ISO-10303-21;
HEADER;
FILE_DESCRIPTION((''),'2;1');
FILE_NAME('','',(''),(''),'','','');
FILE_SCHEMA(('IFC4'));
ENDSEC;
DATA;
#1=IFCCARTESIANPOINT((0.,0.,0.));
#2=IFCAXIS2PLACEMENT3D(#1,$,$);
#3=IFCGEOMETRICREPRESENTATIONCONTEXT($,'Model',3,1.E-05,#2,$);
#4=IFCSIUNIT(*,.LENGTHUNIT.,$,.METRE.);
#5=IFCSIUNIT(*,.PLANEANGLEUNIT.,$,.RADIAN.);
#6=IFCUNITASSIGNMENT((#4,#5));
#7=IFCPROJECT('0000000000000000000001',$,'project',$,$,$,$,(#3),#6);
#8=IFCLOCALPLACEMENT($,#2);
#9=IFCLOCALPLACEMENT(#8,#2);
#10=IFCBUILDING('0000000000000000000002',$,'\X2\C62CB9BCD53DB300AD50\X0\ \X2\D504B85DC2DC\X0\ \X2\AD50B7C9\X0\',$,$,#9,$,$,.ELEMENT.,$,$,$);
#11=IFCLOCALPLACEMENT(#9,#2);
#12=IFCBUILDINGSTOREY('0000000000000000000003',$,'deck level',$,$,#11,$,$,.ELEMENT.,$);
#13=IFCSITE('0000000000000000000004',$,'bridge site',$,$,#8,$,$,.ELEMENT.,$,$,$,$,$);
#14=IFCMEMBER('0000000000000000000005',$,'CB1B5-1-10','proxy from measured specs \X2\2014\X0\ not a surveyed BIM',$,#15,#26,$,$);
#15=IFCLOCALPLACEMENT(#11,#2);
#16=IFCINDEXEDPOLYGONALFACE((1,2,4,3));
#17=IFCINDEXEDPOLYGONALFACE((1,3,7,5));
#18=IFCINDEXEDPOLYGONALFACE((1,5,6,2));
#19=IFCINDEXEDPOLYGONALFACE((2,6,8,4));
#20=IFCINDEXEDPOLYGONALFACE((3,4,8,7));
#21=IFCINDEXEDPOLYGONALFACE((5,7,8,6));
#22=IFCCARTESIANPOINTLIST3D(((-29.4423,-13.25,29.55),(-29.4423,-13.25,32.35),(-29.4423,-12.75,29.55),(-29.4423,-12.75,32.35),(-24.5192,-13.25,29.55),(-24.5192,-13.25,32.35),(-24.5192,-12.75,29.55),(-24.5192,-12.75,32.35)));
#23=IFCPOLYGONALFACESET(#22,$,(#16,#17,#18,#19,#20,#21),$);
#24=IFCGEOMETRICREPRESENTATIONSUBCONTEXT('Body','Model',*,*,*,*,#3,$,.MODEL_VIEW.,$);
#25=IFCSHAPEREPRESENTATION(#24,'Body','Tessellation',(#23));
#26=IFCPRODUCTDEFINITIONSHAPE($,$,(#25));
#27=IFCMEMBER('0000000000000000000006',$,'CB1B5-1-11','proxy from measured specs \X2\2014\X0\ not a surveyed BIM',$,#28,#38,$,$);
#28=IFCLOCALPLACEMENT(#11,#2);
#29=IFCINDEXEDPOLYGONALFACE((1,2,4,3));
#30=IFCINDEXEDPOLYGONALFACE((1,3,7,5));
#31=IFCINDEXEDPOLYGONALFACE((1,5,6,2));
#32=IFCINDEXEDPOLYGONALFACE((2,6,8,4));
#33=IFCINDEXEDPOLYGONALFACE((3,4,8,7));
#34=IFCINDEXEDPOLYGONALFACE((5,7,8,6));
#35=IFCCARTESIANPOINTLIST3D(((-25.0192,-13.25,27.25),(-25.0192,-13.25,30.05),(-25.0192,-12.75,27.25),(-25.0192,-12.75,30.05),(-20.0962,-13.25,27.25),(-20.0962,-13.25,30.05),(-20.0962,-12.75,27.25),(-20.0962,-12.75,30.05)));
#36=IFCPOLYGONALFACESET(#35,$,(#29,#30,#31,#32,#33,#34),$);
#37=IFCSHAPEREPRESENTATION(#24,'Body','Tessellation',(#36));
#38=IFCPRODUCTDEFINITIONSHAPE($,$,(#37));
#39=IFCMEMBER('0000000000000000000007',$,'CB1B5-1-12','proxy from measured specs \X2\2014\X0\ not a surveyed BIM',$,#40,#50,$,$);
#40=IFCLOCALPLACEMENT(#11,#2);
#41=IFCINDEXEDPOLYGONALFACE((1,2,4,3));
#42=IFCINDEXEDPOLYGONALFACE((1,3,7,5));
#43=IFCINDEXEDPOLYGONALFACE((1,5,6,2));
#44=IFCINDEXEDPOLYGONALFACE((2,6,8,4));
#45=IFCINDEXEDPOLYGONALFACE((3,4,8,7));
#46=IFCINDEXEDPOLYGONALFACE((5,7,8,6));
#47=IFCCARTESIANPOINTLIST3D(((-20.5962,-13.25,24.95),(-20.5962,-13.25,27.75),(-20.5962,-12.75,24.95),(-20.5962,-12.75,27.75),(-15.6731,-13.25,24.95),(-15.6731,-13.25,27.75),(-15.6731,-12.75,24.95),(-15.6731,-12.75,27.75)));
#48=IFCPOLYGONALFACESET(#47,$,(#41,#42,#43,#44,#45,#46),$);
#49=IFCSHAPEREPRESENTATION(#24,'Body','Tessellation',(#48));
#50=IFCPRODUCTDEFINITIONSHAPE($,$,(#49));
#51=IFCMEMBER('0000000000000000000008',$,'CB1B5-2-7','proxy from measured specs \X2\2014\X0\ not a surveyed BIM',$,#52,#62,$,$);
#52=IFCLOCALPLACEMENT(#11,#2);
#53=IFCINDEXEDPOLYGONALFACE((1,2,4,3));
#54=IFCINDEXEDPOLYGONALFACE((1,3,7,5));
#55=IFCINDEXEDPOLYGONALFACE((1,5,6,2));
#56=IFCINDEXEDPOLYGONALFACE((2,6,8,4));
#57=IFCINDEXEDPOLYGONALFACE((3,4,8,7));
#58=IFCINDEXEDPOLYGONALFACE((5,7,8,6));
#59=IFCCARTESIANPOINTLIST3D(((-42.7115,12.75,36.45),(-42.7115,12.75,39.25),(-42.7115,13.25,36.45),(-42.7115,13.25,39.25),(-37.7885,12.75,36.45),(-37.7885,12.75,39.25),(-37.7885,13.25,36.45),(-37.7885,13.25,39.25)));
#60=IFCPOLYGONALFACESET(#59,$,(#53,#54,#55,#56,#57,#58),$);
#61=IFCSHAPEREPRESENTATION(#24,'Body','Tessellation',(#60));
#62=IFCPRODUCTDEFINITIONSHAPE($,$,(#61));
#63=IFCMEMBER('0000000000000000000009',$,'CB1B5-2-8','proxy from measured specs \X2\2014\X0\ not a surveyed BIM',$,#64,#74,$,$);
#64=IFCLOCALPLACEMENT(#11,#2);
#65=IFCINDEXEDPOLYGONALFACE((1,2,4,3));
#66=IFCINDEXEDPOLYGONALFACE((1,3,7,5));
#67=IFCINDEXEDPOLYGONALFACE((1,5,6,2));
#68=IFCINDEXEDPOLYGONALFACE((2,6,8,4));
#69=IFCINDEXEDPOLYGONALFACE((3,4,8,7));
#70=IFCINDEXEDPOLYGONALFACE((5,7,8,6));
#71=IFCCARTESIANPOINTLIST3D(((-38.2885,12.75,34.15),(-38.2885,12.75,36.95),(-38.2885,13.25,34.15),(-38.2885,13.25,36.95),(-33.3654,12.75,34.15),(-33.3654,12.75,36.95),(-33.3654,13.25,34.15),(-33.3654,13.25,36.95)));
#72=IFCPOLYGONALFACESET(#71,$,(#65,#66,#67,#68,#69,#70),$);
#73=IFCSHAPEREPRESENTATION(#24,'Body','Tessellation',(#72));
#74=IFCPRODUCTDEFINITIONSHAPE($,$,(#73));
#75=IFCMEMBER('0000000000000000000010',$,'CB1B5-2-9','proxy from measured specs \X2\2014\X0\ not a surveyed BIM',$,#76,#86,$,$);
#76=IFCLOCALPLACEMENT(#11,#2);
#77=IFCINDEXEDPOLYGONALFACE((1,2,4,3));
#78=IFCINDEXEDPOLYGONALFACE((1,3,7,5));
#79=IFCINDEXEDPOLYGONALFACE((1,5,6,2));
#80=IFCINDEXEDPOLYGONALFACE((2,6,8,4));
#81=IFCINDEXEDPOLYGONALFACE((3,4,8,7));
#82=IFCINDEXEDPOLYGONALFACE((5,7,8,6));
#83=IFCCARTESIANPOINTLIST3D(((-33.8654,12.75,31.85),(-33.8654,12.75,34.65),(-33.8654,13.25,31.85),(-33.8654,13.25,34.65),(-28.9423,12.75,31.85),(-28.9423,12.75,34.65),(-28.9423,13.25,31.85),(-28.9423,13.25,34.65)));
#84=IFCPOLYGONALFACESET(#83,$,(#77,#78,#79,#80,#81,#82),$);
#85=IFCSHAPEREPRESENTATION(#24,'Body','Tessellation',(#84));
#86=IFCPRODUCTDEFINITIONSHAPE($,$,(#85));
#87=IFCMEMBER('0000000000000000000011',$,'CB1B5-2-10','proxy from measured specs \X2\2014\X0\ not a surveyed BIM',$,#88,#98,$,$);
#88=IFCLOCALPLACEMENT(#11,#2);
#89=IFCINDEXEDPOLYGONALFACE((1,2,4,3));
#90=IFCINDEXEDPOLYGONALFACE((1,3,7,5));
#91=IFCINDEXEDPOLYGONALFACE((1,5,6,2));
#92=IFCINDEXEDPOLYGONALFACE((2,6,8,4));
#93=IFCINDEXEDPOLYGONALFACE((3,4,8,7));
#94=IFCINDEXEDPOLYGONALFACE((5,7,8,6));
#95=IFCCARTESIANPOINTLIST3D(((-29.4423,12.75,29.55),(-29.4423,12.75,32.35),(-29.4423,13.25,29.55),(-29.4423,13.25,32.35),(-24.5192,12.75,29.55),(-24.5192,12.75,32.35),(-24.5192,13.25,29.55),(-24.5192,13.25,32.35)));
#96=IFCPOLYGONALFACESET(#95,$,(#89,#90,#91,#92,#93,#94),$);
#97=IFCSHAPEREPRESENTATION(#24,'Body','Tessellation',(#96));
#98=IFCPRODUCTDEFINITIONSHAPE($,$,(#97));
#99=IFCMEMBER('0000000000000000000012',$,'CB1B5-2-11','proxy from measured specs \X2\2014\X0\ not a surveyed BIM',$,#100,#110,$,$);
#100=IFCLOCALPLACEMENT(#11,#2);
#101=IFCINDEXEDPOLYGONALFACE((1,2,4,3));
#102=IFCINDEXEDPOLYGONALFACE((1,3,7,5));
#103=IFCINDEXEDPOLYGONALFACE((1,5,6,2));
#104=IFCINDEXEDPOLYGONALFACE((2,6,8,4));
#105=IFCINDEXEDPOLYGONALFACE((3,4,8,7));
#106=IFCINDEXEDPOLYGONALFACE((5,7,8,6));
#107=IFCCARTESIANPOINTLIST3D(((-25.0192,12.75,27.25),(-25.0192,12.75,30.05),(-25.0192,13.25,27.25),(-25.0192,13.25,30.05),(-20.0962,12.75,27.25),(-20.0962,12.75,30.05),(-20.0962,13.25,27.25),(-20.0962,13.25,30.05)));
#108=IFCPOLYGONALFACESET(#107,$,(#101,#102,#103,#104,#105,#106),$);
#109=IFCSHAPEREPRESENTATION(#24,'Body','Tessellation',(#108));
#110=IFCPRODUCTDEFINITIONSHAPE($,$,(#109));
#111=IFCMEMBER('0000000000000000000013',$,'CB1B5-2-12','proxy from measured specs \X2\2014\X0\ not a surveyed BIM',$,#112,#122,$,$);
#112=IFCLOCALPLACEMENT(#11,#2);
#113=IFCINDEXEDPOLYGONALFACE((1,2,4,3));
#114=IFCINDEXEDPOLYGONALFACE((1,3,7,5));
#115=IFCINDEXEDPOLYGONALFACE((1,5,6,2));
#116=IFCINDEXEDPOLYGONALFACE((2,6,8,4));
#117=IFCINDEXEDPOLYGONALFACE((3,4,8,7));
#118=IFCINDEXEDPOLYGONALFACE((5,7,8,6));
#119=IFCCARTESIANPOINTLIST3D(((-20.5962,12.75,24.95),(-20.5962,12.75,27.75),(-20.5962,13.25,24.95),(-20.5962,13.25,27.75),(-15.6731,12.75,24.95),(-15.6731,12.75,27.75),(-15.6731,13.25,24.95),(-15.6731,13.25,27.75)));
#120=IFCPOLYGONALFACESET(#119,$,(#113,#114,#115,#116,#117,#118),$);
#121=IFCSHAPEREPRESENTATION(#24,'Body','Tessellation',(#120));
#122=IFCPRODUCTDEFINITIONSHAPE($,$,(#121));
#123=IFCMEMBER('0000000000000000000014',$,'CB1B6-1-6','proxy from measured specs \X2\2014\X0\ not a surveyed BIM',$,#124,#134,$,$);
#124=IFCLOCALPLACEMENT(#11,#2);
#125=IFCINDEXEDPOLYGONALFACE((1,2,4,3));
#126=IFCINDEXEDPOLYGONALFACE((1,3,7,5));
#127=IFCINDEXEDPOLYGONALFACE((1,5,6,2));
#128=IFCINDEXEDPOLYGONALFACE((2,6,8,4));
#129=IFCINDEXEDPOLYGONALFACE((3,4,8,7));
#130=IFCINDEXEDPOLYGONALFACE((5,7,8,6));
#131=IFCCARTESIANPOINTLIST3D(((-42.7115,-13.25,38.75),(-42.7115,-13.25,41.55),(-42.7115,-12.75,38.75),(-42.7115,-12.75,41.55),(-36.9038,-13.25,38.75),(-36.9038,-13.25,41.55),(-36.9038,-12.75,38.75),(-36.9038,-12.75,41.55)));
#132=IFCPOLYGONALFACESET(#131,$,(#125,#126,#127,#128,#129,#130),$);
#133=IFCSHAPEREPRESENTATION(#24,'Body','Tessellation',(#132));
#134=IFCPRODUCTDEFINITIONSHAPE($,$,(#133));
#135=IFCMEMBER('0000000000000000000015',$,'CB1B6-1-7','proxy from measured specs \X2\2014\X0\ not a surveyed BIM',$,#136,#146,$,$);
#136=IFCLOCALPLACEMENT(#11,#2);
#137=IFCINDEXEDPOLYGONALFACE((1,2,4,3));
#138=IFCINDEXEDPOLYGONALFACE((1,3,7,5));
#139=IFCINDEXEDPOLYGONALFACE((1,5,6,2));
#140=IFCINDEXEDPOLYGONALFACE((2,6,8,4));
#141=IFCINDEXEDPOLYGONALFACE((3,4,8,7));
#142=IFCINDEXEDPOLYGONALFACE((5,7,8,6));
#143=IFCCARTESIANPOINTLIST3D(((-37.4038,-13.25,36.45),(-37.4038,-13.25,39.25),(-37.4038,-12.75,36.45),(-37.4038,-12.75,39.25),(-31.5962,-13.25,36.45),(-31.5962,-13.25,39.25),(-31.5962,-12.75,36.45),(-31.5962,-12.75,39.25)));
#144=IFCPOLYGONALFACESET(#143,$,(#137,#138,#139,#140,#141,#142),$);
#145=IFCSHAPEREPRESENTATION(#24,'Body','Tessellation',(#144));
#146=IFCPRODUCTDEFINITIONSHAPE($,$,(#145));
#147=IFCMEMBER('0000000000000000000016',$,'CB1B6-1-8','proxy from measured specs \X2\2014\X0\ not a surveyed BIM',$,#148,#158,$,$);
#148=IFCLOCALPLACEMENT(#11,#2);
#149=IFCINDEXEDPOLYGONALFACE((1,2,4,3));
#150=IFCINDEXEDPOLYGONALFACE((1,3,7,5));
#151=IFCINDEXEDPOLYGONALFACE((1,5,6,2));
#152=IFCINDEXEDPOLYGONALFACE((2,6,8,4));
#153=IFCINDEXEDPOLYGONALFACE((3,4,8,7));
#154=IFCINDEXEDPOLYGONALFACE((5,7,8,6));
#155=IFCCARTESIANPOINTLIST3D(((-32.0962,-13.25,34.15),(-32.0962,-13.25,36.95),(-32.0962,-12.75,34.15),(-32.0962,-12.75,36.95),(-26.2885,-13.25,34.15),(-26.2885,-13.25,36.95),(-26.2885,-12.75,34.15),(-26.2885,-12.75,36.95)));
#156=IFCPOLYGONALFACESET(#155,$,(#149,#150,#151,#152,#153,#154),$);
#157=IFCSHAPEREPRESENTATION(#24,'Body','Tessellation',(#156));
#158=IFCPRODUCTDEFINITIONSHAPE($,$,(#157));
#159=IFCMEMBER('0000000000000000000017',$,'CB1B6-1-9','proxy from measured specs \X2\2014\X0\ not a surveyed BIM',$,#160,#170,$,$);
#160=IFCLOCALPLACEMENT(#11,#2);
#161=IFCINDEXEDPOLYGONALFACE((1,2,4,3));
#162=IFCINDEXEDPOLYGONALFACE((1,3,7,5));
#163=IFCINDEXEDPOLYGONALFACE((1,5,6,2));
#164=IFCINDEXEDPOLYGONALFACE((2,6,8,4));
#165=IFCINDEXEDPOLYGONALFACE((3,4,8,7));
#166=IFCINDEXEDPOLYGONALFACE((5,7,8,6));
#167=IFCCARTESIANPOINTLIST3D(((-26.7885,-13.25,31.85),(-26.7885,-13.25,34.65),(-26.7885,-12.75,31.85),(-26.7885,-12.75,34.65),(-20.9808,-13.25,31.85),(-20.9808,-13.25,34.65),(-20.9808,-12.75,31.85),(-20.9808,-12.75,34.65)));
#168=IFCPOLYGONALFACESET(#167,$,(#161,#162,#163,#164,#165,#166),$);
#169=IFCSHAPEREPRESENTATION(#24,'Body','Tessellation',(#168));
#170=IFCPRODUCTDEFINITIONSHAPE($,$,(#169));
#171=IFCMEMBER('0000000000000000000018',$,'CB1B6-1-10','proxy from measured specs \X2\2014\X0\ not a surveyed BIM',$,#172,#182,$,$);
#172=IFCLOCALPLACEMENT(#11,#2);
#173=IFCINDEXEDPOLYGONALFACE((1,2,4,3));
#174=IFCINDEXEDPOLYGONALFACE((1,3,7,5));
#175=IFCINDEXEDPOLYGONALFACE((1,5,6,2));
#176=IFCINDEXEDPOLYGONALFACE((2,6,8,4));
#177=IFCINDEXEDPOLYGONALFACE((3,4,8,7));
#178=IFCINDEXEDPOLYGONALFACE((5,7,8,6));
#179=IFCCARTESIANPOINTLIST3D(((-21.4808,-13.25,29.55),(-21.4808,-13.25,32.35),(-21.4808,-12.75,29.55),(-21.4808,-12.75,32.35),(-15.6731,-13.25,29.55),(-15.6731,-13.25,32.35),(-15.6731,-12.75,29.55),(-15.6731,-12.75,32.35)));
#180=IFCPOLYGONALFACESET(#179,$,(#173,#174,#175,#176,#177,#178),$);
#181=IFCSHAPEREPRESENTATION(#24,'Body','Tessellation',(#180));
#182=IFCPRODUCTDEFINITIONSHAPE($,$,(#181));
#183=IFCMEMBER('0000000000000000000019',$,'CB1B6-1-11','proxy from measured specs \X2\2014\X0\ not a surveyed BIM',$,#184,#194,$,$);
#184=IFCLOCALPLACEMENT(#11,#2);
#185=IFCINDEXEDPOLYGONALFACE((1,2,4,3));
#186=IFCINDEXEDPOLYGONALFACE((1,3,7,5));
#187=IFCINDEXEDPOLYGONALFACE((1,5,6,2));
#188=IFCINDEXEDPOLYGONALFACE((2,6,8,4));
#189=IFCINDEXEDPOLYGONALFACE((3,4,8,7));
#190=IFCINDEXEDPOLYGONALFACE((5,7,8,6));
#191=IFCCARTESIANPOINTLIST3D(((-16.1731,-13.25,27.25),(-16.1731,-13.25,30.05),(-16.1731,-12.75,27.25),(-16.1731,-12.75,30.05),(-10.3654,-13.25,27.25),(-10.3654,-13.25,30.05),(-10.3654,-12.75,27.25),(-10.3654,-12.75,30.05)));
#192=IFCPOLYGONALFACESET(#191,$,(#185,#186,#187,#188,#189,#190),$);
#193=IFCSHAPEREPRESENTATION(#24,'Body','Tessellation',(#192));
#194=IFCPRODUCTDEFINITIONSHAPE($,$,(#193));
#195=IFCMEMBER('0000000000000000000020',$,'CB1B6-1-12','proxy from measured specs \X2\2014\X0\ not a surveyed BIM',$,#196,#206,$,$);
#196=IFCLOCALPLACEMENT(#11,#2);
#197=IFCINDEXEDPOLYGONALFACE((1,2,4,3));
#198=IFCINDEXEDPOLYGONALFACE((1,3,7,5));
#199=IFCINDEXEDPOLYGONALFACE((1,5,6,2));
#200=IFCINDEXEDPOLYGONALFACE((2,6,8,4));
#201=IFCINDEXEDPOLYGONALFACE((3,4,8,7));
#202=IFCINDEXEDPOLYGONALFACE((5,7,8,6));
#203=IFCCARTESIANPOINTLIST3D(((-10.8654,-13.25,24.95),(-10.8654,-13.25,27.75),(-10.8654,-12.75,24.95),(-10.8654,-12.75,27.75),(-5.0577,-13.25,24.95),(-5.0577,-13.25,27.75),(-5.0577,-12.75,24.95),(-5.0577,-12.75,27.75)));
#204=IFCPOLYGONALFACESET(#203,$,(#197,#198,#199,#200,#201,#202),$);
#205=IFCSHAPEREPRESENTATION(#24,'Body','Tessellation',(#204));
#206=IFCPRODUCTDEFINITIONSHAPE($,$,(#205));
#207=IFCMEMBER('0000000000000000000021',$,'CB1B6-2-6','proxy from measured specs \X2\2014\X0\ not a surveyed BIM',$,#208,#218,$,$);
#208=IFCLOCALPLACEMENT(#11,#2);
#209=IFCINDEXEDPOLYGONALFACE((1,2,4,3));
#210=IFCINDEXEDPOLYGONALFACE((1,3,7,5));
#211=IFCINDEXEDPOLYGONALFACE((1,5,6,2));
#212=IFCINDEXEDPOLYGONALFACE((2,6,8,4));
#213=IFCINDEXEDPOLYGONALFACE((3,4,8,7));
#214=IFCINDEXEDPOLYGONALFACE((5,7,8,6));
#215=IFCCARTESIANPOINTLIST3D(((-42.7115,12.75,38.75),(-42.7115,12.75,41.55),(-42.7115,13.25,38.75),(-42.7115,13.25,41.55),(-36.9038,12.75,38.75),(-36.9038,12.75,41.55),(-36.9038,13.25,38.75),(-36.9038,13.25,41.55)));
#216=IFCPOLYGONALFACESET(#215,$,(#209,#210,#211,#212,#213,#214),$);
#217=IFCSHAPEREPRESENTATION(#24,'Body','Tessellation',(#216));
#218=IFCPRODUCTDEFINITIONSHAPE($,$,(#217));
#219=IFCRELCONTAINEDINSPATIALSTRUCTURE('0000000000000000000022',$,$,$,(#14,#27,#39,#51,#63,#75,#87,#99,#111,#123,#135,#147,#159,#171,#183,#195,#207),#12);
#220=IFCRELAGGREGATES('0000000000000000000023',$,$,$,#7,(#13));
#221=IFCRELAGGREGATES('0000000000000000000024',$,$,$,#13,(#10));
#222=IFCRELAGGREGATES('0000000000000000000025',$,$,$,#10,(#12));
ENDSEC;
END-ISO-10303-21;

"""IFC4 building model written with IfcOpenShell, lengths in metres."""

from ifc_helpers import new_model, si_unit, frame, origin, origin_2d, place, context, subcontext, project, spatial, rectangle, extrude, element, save


model = new_model("IFC4")

# Units and contexts
model_context = context("Model", 3, precision=1e-05, world=origin())
body_context = subcontext(model_context, "Body", "Model", "MODEL_VIEW")
ifc_project = project(units=[si_unit("LENGTHUNIT", "METRE"), si_unit("PLANEANGLEUNIT", "RADIAN")], contexts=[model_context])

# Site, building, storey
site_placement = place(None, origin())
site = spatial("IfcSite", under=ifc_project, at=site_placement, Name="bridge site", CompositionType="ELEMENT")
building_placement = place(site_placement, origin())
building = spatial("IfcBuilding", under=site, at=building_placement, Name="올림픽대교 프록시 교량", CompositionType="ELEMENT")
storey_placement = place(building_placement, origin())
storey = spatial("IfcBuildingStorey", under=building, at=storey_placement, Name="deck level", CompositionType="ELEMENT")

# Members
member_1_placement = place(storey_placement, frame((-26.9808, -13.0, 29.55)))
element("IfcMember", 1, at=member_1_placement, inside=storey, Name="CB1B5-1-10", Description="proxy from measured specs — not a surveyed BIM", context=body_context, shape_type="SweptSolid", body=[
    extrude(rectangle(XDim=4.9231, YDim=0.5, at=origin_2d()), origin(), (0.0, 0.0, 1.0), 2.8),
])
member_2_placement = place(storey_placement, frame((-22.5577, -13.0, 27.25)))
element("IfcMember", 2, at=member_2_placement, inside=storey, Name="CB1B5-1-11", Description="proxy from measured specs — not a surveyed BIM", context=body_context, shape_type="SweptSolid", body=[
    extrude(rectangle(XDim=4.9231, YDim=0.5, at=origin_2d()), origin(), (0.0, 0.0, 1.0), 2.8),
])
member_3_placement = place(storey_placement, frame((-18.1346, -13.0, 24.95)))
element("IfcMember", 3, at=member_3_placement, inside=storey, Name="CB1B5-1-12", Description="proxy from measured specs — not a surveyed BIM", context=body_context, shape_type="SweptSolid", body=[
    extrude(rectangle(XDim=4.9231, YDim=0.5, at=origin_2d()), origin(), (0.0, 0.0, 1.0), 2.8),
])
member_4_placement = place(storey_placement, frame((-40.25, 13.0, 36.45)))
element("IfcMember", 4, at=member_4_placement, inside=storey, Name="CB1B5-2-7", Description="proxy from measured specs — not a surveyed BIM", context=body_context, shape_type="SweptSolid", body=[
    extrude(rectangle(XDim=4.9231, YDim=0.5, at=origin_2d()), origin(), (0.0, 0.0, 1.0), 2.8),
])
member_5_placement = place(storey_placement, frame((-35.8269, 13.0, 34.15)))
element("IfcMember", 5, at=member_5_placement, inside=storey, Name="CB1B5-2-8", Description="proxy from measured specs — not a surveyed BIM", context=body_context, shape_type="SweptSolid", body=[
    extrude(rectangle(XDim=4.9231, YDim=0.5, at=origin_2d()), origin(), (0.0, 0.0, 1.0), 2.8),
])
member_6_placement = place(storey_placement, frame((-31.4038, 13.0, 31.85)))
element("IfcMember", 6, at=member_6_placement, inside=storey, Name="CB1B5-2-9", Description="proxy from measured specs — not a surveyed BIM", context=body_context, shape_type="SweptSolid", body=[
    extrude(rectangle(XDim=4.9231, YDim=0.5, at=origin_2d()), origin(), (0.0, 0.0, 1.0), 2.8),
])
member_7_placement = place(storey_placement, frame((-26.9808, 13.0, 29.55)))
element("IfcMember", 7, at=member_7_placement, inside=storey, Name="CB1B5-2-10", Description="proxy from measured specs — not a surveyed BIM", context=body_context, shape_type="SweptSolid", body=[
    extrude(rectangle(XDim=4.9231, YDim=0.5, at=origin_2d()), origin(), (0.0, 0.0, 1.0), 2.8),
])
member_8_placement = place(storey_placement, frame((-22.5577, 13.0, 27.25)))
element("IfcMember", 8, at=member_8_placement, inside=storey, Name="CB1B5-2-11", Description="proxy from measured specs — not a surveyed BIM", context=body_context, shape_type="SweptSolid", body=[
    extrude(rectangle(XDim=4.9231, YDim=0.5, at=origin_2d()), origin(), (0.0, 0.0, 1.0), 2.8),
])
member_9_placement = place(storey_placement, frame((-18.1346, 13.0, 24.95)))
element("IfcMember", 9, at=member_9_placement, inside=storey, Name="CB1B5-2-12", Description="proxy from measured specs — not a surveyed BIM", context=body_context, shape_type="SweptSolid", body=[
    extrude(rectangle(XDim=4.9231, YDim=0.5, at=origin_2d()), origin(), (0.0, 0.0, 1.0), 2.8),
])
member_10_placement = place(storey_placement, frame((-39.8077, -13.0, 38.75)))
element("IfcMember", 10, at=member_10_placement, inside=storey, Name="CB1B6-1-6", Description="proxy from measured specs — not a surveyed BIM", context=body_context, shape_type="SweptSolid", body=[
    extrude(rectangle(XDim=5.8077, YDim=0.5, at=origin_2d()), origin(), (0.0, 0.0, 1.0), 2.8),
])
member_11_placement = place(storey_placement, frame((-34.5, -13.0, 36.45)))
element("IfcMember", 11, at=member_11_placement, inside=storey, Name="CB1B6-1-7", Description="proxy from measured specs — not a surveyed BIM", context=body_context, shape_type="SweptSolid", body=[
    extrude(rectangle(XDim=5.8077, YDim=0.5, at=origin_2d()), origin(), (0.0, 0.0, 1.0), 2.8),
])
member_12_placement = place(storey_placement, frame((-29.1923, -13.0, 34.15)))
element("IfcMember", 12, at=member_12_placement, inside=storey, Name="CB1B6-1-8", Description="proxy from measured specs — not a surveyed BIM", context=body_context, shape_type="SweptSolid", body=[
    extrude(rectangle(XDim=5.8077, YDim=0.5, at=origin_2d()), origin(), (0.0, 0.0, 1.0), 2.8),
])
member_13_placement = place(storey_placement, frame((-23.8846, -13.0, 31.85)))
element("IfcMember", 13, at=member_13_placement, inside=storey, Name="CB1B6-1-9", Description="proxy from measured specs — not a surveyed BIM", context=body_context, shape_type="SweptSolid", body=[
    extrude(rectangle(XDim=5.8077, YDim=0.5, at=origin_2d()), origin(), (0.0, 0.0, 1.0), 2.8),
])
member_14_placement = place(storey_placement, frame((-18.5769, -13.0, 29.55)))
element("IfcMember", 14, at=member_14_placement, inside=storey, Name="CB1B6-1-10", Description="proxy from measured specs — not a surveyed BIM", context=body_context, shape_type="SweptSolid", body=[
    extrude(rectangle(XDim=5.8077, YDim=0.5, at=origin_2d()), origin(), (0.0, 0.0, 1.0), 2.8),
])
member_15_placement = place(storey_placement, frame((-13.2692, -13.0, 27.25)))
element("IfcMember", 15, at=member_15_placement, inside=storey, Name="CB1B6-1-11", Description="proxy from measured specs — not a surveyed BIM", context=body_context, shape_type="SweptSolid", body=[
    extrude(rectangle(XDim=5.8077, YDim=0.5, at=origin_2d()), origin(), (0.0, 0.0, 1.0), 2.8),
])
member_16_placement = place(storey_placement, frame((-7.9615, -13.0, 24.95)))
element("IfcMember", 16, at=member_16_placement, inside=storey, Name="CB1B6-1-12", Description="proxy from measured specs — not a surveyed BIM", context=body_context, shape_type="SweptSolid", body=[
    extrude(rectangle(XDim=5.8077, YDim=0.5, at=origin_2d()), origin(), (0.0, 0.0, 1.0), 2.8),
])
member_17_placement = place(storey_placement, frame((-39.8077, 13.0, 38.75)))
element("IfcMember", 17, at=member_17_placement, inside=storey, Name="CB1B6-2-6", Description="proxy from measured specs — not a surveyed BIM", context=body_context, shape_type="SweptSolid", body=[
    extrude(rectangle(XDim=5.8077, YDim=0.5, at=origin_2d()), origin(), (0.0, 0.0, 1.0), 2.8),
])

save(model, "model.ifc")
